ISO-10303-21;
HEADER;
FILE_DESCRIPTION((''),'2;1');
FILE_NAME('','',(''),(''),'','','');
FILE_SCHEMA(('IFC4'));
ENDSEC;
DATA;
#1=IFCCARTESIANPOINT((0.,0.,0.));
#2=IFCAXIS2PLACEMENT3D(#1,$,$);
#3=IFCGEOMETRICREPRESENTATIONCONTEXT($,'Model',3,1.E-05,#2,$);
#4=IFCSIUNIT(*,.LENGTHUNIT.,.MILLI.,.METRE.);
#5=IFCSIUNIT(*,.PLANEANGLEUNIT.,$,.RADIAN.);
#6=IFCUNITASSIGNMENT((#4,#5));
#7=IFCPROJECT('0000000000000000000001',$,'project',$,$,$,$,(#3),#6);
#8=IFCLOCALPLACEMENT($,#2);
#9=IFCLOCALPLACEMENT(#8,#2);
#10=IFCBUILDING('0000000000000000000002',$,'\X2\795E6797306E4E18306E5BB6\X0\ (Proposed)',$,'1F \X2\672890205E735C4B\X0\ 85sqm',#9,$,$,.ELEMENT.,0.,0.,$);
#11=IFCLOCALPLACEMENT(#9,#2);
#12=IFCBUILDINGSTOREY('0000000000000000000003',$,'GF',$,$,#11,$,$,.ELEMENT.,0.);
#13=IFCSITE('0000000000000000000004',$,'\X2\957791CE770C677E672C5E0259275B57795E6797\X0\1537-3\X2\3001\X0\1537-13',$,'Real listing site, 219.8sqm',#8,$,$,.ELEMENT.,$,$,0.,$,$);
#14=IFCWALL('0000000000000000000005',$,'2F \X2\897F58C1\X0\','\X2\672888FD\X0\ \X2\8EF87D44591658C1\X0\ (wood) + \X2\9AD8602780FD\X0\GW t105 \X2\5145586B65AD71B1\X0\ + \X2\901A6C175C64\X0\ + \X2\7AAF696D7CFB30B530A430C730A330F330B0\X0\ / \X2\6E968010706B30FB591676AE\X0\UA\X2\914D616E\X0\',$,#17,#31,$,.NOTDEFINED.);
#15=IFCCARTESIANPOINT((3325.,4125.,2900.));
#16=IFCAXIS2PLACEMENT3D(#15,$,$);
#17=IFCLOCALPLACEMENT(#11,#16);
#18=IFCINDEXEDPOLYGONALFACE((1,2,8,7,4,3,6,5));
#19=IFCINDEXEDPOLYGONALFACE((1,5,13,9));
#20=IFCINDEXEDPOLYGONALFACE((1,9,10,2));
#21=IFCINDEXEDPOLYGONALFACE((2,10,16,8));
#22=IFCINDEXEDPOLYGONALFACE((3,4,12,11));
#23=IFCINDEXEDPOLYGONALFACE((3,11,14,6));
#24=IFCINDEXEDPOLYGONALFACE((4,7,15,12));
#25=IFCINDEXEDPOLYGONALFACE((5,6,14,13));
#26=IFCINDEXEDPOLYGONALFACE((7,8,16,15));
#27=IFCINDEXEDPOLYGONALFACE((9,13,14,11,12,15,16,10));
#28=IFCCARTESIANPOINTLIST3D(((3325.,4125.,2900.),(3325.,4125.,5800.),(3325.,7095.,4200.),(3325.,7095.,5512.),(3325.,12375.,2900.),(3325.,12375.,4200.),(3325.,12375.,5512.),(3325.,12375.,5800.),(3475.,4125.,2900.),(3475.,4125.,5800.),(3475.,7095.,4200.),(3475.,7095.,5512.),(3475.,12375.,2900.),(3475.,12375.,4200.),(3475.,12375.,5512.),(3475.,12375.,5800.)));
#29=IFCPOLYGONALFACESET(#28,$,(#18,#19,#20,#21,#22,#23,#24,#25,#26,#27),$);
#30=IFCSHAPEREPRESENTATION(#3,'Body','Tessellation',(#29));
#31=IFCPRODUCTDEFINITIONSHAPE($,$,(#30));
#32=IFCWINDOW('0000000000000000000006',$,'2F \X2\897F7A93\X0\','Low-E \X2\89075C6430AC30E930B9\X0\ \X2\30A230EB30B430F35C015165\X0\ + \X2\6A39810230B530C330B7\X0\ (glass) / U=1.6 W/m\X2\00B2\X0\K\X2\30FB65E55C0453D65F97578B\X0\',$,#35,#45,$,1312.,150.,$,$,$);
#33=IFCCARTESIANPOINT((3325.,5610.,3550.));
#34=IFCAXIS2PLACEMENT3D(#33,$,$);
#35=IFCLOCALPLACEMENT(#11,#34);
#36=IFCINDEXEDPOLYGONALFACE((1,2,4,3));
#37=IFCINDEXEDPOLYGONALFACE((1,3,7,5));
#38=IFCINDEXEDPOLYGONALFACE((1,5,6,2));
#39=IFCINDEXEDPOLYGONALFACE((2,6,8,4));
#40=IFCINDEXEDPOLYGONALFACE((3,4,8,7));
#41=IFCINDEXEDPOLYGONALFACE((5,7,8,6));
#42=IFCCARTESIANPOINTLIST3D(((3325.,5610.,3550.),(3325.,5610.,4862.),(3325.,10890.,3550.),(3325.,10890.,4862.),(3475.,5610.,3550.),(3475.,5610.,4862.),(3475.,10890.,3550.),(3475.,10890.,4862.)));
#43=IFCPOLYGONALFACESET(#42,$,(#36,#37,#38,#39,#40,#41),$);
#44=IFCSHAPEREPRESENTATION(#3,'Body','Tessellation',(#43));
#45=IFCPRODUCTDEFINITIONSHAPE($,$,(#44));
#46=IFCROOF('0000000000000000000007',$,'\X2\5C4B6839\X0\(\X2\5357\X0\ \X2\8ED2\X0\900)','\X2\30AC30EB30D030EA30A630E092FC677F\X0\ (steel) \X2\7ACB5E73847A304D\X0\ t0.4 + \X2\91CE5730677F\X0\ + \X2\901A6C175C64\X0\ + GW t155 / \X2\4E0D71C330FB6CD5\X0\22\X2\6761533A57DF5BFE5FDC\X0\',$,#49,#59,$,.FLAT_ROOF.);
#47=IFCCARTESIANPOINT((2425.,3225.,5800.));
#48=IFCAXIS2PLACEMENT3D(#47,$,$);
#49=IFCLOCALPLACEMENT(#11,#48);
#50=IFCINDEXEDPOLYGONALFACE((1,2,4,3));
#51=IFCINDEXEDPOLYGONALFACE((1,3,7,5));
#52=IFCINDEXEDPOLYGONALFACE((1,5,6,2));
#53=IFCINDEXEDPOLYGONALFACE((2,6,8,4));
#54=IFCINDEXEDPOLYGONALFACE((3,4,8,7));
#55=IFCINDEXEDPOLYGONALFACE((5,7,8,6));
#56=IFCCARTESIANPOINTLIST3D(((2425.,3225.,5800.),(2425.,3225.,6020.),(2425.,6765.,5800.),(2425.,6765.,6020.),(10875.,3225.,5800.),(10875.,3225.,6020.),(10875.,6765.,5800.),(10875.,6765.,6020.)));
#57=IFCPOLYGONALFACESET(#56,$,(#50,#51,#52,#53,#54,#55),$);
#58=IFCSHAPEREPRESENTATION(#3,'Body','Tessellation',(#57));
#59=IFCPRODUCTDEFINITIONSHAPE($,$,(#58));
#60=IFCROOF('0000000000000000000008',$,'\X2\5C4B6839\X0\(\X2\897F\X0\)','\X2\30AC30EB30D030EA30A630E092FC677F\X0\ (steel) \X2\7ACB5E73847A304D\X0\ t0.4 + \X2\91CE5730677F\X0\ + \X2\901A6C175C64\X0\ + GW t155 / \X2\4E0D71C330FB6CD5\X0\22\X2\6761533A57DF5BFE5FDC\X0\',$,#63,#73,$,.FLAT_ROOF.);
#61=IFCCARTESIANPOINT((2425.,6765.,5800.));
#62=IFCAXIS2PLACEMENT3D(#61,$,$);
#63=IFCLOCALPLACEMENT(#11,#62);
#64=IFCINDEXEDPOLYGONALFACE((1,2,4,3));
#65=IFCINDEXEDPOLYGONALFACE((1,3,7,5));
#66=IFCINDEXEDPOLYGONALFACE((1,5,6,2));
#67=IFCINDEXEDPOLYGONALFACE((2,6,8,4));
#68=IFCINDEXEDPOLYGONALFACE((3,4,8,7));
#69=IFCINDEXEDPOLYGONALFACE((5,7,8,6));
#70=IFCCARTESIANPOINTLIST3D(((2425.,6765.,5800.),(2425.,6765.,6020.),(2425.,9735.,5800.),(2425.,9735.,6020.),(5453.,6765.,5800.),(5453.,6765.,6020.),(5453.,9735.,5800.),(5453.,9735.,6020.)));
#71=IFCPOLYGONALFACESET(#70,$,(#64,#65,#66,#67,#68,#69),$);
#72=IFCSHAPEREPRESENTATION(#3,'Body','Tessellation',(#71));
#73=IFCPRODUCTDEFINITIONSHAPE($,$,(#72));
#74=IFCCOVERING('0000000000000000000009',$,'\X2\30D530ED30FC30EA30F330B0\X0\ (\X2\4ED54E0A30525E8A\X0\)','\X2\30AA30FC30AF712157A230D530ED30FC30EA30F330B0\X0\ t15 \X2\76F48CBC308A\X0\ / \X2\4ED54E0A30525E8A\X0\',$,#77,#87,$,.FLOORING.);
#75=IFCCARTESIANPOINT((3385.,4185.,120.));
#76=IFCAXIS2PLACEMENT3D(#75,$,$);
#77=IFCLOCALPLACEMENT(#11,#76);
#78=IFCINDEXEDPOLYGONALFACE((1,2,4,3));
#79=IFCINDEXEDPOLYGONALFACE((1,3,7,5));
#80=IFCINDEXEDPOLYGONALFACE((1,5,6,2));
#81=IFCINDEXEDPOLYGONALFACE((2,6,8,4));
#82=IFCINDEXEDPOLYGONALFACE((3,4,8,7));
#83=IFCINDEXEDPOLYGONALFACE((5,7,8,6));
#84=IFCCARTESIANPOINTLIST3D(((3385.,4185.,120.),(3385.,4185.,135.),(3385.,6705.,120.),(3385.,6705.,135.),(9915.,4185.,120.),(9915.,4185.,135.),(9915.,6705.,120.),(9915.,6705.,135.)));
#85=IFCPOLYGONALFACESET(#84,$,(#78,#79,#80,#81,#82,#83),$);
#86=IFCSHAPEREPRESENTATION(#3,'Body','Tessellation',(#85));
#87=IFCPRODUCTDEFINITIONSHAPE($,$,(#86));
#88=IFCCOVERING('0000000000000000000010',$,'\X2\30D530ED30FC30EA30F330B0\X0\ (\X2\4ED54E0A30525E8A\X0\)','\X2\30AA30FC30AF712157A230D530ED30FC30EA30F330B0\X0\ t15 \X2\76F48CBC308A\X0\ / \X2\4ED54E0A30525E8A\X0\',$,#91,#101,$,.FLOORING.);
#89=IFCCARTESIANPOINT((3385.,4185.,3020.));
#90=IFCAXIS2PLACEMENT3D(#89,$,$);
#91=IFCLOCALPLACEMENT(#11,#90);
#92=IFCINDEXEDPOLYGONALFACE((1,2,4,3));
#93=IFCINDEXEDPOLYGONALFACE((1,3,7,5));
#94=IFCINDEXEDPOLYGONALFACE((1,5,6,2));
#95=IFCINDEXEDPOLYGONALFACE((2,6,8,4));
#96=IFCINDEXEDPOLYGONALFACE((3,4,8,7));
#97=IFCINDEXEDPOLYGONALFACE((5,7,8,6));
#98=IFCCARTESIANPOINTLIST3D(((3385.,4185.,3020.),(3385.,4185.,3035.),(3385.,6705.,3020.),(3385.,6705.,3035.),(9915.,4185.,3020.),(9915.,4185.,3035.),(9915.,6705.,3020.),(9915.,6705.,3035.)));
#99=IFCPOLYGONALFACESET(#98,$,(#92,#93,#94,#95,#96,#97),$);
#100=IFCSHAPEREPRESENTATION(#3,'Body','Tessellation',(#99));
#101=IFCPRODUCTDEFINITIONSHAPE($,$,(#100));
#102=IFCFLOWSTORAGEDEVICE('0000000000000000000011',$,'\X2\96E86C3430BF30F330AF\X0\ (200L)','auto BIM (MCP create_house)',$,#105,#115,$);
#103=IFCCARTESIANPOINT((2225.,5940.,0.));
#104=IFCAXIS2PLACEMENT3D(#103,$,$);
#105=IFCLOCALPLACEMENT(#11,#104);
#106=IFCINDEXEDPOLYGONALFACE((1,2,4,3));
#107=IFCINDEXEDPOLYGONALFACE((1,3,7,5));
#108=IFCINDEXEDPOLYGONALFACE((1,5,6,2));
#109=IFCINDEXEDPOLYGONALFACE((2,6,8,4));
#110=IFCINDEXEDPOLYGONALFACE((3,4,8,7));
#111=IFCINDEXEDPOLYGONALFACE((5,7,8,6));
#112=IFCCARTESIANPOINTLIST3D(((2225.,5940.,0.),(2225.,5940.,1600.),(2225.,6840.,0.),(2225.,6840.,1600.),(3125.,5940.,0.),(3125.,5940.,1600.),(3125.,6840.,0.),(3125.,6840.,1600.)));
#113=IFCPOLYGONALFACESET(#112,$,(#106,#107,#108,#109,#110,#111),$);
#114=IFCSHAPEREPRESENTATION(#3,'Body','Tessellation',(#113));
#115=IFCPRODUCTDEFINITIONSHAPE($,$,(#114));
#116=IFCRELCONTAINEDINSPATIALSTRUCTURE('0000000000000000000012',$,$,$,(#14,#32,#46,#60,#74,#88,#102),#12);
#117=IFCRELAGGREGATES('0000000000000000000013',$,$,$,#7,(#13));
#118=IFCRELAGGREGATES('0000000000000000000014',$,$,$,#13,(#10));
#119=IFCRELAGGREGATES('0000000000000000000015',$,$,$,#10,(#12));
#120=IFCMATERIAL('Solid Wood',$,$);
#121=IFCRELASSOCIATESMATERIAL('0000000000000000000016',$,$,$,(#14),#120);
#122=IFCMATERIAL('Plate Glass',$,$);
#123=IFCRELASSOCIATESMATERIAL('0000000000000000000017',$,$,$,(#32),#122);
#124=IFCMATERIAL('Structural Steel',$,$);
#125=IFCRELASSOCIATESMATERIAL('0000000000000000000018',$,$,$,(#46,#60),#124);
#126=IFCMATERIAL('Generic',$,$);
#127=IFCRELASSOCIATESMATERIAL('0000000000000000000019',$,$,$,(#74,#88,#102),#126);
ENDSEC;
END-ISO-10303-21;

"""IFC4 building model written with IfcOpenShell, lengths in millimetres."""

from ifc_helpers import new_model, si_unit, frame, frame_2d, origin, place, context, project, spatial, rectangle, extrude, material, element, fill, save


model = new_model("IFC4")

# Units and contexts
model_context = context("Model", 3, precision=1e-05, world=origin())
ifc_project = project(units=[si_unit("LENGTHUNIT", "METRE", prefix="MILLI"), si_unit("PLANEANGLEUNIT", "RADIAN")], contexts=[model_context])

# Site, building, storey
site_placement = place(None, origin())
site = spatial("IfcSite", under=ifc_project, at=site_placement, Name="長野県松本市大字神林1537-3、1537-13", ObjectType="Real listing site, 219.8sqm", CompositionType="ELEMENT", RefElevation=0.0)
building_placement = place(site_placement, origin())
building = spatial("IfcBuilding", under=site, at=building_placement, Name="神林の丘の家 (Proposed)", ObjectType="1F 木造平屋 85sqm", CompositionType="ELEMENT", ElevationOfRefHeight=0.0, ElevationOfTerrain=0.0)
storey_placement = place(building_placement, origin())
storey = spatial("IfcBuildingStorey", under=building, at=storey_placement, Name="GF", CompositionType="ELEMENT", Elevation=0.0)

# Shared definitions
ifc_material_1 = material(Name="Solid Wood")
ifc_material_2 = material(Name="Generic")

# Shared definitions
ifc_material_3 = material(Name="Plate Glass")

# Wall, opening, window
wall_1_placement = place(storey_placement, frame((3325.0, 4125.0, 2900.0)))
wall_1 = element("IfcWall", 1, at=wall_1_placement, inside=storey, material=ifc_material_1, Name="2F 西壁", Description="木製 軸組外壁 (wood) + 高性能GW t105 充填断熱 + 通気層 + 窯業系サイディング / 準耐火・外皮UA配慮", PredefinedType="NOTDEFINED", context=model_context, shape_type="SweptSolid", body=[
    extrude(rectangle(XDim=150.0, YDim=8250.0, at=frame_2d((75.0, 4125.0))), frame((3325.0, 4125.0, 2900.0)), (0.0, 0.0, 1.0), 2900.0),
])
opening_1_placement = place(storey_placement, frame((3325.0, 5610.0, 3550.0)))
opening_1 = element("IfcOpeningElement", 2, at=opening_1_placement, cuts=wall_1, PredefinedType="NOTDEFINED", context=model_context, shape_type="SweptSolid", body=[
    extrude(rectangle(XDim=150.0, YDim=5280.0, at=frame_2d((75.0, 2640.0))), frame((3325.0, 5610.0, 3550.0)), (0.0, 0.0, 1.0), 1312.0),
])
window_1_placement = place(storey_placement, frame((3325.0, 5610.0, 3550.0)))
window_1 = element("IfcWindow", 3, at=window_1_placement, inside=storey, material=ifc_material_3, Name="2F 西窓", Description="Low-E 複層ガラス アルゴン封入 + 樹脂サッシ (glass) / U=1.6 W/m²K・日射取得型", OverallHeight=1312.0, OverallWidth=150.0, context=model_context, shape_type="SweptSolid", body=[
    extrude(rectangle(XDim=150.0, YDim=5280.0, at=frame_2d((75.0, 2640.0))), frame((3325.0, 5610.0, 3550.0)), (0.0, 0.0, 1.0), 1312.0),
])
fill(opening_1, window_1)

# Roofs
ifc_material_4 = material(Name="Structural Steel")
roof_1_placement = place(storey_placement, frame((2425.0, 3225.0, 5800.0)))
element("IfcRoof", 4, at=roof_1_placement, inside=storey, material=ifc_material_4, Name="屋根(南 軒900)", Description="ガルバリウム鋼板 (steel) 立平葺き t0.4 + 野地板 + 通気層 + GW t155 / 不燃・法22条区域対応", PredefinedType="FLAT_ROOF", context=model_context, shape_type="SweptSolid", body=[
    extrude(rectangle(XDim=8450.0, YDim=3540.0, at=frame_2d((4225.0, 1770.0))), frame((2425.0, 3225.0, 5800.0)), (0.0, 0.0, 1.0), 220.0),
])
roof_2_placement = place(storey_placement, frame((2425.0, 6765.0, 5800.0)))
element("IfcRoof", 5, at=roof_2_placement, inside=storey, material=ifc_material_4, Name="屋根(西)", Description="ガルバリウム鋼板 (steel) 立平葺き t0.4 + 野地板 + 通気層 + GW t155 / 不燃・法22条区域対応", PredefinedType="FLAT_ROOF", context=model_context, shape_type="SweptSolid", body=[
    extrude(rectangle(XDim=3028.0, YDim=2970.0, at=frame_2d((1514.0, 1485.0))), frame((2425.0, 6765.0, 5800.0)), (0.0, 0.0, 1.0), 220.0),
])

# Coverings
covering_1_placement = place(storey_placement, frame((3385.0, 4185.0, 120.0)))
element("IfcCovering", 6, at=covering_1_placement, inside=storey, material=ifc_material_2, Name="フローリング (仕上げ床)", Description="オーク無垢フローリング t15 直貼り / 仕上げ床", PredefinedType="FLOORING", context=model_context, shape_type="SweptSolid", body=[
    extrude(rectangle(XDim=6530.0, YDim=2520.0, at=frame_2d((3265.0, 1260.0))), frame((3385.0, 4185.0, 120.0)), (0.0, 0.0, 1.0), 15.0),
])
covering_2_placement = place(storey_placement, frame((3385.0, 4185.0, 3020.0)))
element("IfcCovering", 7, at=covering_2_placement, inside=storey, material=ifc_material_2, Name="フローリング (仕上げ床)", Description="オーク無垢フローリング t15 直貼り / 仕上げ床", PredefinedType="FLOORING", context=model_context, shape_type="SweptSolid", body=[
    extrude(rectangle(XDim=6530.0, YDim=2520.0, at=frame_2d((3265.0, 1260.0))), frame((3385.0, 4185.0, 3020.0)), (0.0, 0.0, 1.0), 15.0),
])

# Flow storage device
flow_storage_device_placement = place(storey_placement, frame((2225.0, 5940.0, 0.0)))
element("IfcFlowStorageDevice", 8, at=flow_storage_device_placement, inside=storey, material=ifc_material_2, Name="雨水タンク (200L)", Description="auto BIM (MCP create_house)", context=model_context, shape_type="SweptSolid", body=[
    extrude(rectangle(XDim=900.0, YDim=900.0, at=frame_2d((450.0, 450.0))), frame((2225.0, 5940.0, 0.0)), (0.0, 0.0, 1.0), 1600.0),
])

save(model, "model.ifc")
